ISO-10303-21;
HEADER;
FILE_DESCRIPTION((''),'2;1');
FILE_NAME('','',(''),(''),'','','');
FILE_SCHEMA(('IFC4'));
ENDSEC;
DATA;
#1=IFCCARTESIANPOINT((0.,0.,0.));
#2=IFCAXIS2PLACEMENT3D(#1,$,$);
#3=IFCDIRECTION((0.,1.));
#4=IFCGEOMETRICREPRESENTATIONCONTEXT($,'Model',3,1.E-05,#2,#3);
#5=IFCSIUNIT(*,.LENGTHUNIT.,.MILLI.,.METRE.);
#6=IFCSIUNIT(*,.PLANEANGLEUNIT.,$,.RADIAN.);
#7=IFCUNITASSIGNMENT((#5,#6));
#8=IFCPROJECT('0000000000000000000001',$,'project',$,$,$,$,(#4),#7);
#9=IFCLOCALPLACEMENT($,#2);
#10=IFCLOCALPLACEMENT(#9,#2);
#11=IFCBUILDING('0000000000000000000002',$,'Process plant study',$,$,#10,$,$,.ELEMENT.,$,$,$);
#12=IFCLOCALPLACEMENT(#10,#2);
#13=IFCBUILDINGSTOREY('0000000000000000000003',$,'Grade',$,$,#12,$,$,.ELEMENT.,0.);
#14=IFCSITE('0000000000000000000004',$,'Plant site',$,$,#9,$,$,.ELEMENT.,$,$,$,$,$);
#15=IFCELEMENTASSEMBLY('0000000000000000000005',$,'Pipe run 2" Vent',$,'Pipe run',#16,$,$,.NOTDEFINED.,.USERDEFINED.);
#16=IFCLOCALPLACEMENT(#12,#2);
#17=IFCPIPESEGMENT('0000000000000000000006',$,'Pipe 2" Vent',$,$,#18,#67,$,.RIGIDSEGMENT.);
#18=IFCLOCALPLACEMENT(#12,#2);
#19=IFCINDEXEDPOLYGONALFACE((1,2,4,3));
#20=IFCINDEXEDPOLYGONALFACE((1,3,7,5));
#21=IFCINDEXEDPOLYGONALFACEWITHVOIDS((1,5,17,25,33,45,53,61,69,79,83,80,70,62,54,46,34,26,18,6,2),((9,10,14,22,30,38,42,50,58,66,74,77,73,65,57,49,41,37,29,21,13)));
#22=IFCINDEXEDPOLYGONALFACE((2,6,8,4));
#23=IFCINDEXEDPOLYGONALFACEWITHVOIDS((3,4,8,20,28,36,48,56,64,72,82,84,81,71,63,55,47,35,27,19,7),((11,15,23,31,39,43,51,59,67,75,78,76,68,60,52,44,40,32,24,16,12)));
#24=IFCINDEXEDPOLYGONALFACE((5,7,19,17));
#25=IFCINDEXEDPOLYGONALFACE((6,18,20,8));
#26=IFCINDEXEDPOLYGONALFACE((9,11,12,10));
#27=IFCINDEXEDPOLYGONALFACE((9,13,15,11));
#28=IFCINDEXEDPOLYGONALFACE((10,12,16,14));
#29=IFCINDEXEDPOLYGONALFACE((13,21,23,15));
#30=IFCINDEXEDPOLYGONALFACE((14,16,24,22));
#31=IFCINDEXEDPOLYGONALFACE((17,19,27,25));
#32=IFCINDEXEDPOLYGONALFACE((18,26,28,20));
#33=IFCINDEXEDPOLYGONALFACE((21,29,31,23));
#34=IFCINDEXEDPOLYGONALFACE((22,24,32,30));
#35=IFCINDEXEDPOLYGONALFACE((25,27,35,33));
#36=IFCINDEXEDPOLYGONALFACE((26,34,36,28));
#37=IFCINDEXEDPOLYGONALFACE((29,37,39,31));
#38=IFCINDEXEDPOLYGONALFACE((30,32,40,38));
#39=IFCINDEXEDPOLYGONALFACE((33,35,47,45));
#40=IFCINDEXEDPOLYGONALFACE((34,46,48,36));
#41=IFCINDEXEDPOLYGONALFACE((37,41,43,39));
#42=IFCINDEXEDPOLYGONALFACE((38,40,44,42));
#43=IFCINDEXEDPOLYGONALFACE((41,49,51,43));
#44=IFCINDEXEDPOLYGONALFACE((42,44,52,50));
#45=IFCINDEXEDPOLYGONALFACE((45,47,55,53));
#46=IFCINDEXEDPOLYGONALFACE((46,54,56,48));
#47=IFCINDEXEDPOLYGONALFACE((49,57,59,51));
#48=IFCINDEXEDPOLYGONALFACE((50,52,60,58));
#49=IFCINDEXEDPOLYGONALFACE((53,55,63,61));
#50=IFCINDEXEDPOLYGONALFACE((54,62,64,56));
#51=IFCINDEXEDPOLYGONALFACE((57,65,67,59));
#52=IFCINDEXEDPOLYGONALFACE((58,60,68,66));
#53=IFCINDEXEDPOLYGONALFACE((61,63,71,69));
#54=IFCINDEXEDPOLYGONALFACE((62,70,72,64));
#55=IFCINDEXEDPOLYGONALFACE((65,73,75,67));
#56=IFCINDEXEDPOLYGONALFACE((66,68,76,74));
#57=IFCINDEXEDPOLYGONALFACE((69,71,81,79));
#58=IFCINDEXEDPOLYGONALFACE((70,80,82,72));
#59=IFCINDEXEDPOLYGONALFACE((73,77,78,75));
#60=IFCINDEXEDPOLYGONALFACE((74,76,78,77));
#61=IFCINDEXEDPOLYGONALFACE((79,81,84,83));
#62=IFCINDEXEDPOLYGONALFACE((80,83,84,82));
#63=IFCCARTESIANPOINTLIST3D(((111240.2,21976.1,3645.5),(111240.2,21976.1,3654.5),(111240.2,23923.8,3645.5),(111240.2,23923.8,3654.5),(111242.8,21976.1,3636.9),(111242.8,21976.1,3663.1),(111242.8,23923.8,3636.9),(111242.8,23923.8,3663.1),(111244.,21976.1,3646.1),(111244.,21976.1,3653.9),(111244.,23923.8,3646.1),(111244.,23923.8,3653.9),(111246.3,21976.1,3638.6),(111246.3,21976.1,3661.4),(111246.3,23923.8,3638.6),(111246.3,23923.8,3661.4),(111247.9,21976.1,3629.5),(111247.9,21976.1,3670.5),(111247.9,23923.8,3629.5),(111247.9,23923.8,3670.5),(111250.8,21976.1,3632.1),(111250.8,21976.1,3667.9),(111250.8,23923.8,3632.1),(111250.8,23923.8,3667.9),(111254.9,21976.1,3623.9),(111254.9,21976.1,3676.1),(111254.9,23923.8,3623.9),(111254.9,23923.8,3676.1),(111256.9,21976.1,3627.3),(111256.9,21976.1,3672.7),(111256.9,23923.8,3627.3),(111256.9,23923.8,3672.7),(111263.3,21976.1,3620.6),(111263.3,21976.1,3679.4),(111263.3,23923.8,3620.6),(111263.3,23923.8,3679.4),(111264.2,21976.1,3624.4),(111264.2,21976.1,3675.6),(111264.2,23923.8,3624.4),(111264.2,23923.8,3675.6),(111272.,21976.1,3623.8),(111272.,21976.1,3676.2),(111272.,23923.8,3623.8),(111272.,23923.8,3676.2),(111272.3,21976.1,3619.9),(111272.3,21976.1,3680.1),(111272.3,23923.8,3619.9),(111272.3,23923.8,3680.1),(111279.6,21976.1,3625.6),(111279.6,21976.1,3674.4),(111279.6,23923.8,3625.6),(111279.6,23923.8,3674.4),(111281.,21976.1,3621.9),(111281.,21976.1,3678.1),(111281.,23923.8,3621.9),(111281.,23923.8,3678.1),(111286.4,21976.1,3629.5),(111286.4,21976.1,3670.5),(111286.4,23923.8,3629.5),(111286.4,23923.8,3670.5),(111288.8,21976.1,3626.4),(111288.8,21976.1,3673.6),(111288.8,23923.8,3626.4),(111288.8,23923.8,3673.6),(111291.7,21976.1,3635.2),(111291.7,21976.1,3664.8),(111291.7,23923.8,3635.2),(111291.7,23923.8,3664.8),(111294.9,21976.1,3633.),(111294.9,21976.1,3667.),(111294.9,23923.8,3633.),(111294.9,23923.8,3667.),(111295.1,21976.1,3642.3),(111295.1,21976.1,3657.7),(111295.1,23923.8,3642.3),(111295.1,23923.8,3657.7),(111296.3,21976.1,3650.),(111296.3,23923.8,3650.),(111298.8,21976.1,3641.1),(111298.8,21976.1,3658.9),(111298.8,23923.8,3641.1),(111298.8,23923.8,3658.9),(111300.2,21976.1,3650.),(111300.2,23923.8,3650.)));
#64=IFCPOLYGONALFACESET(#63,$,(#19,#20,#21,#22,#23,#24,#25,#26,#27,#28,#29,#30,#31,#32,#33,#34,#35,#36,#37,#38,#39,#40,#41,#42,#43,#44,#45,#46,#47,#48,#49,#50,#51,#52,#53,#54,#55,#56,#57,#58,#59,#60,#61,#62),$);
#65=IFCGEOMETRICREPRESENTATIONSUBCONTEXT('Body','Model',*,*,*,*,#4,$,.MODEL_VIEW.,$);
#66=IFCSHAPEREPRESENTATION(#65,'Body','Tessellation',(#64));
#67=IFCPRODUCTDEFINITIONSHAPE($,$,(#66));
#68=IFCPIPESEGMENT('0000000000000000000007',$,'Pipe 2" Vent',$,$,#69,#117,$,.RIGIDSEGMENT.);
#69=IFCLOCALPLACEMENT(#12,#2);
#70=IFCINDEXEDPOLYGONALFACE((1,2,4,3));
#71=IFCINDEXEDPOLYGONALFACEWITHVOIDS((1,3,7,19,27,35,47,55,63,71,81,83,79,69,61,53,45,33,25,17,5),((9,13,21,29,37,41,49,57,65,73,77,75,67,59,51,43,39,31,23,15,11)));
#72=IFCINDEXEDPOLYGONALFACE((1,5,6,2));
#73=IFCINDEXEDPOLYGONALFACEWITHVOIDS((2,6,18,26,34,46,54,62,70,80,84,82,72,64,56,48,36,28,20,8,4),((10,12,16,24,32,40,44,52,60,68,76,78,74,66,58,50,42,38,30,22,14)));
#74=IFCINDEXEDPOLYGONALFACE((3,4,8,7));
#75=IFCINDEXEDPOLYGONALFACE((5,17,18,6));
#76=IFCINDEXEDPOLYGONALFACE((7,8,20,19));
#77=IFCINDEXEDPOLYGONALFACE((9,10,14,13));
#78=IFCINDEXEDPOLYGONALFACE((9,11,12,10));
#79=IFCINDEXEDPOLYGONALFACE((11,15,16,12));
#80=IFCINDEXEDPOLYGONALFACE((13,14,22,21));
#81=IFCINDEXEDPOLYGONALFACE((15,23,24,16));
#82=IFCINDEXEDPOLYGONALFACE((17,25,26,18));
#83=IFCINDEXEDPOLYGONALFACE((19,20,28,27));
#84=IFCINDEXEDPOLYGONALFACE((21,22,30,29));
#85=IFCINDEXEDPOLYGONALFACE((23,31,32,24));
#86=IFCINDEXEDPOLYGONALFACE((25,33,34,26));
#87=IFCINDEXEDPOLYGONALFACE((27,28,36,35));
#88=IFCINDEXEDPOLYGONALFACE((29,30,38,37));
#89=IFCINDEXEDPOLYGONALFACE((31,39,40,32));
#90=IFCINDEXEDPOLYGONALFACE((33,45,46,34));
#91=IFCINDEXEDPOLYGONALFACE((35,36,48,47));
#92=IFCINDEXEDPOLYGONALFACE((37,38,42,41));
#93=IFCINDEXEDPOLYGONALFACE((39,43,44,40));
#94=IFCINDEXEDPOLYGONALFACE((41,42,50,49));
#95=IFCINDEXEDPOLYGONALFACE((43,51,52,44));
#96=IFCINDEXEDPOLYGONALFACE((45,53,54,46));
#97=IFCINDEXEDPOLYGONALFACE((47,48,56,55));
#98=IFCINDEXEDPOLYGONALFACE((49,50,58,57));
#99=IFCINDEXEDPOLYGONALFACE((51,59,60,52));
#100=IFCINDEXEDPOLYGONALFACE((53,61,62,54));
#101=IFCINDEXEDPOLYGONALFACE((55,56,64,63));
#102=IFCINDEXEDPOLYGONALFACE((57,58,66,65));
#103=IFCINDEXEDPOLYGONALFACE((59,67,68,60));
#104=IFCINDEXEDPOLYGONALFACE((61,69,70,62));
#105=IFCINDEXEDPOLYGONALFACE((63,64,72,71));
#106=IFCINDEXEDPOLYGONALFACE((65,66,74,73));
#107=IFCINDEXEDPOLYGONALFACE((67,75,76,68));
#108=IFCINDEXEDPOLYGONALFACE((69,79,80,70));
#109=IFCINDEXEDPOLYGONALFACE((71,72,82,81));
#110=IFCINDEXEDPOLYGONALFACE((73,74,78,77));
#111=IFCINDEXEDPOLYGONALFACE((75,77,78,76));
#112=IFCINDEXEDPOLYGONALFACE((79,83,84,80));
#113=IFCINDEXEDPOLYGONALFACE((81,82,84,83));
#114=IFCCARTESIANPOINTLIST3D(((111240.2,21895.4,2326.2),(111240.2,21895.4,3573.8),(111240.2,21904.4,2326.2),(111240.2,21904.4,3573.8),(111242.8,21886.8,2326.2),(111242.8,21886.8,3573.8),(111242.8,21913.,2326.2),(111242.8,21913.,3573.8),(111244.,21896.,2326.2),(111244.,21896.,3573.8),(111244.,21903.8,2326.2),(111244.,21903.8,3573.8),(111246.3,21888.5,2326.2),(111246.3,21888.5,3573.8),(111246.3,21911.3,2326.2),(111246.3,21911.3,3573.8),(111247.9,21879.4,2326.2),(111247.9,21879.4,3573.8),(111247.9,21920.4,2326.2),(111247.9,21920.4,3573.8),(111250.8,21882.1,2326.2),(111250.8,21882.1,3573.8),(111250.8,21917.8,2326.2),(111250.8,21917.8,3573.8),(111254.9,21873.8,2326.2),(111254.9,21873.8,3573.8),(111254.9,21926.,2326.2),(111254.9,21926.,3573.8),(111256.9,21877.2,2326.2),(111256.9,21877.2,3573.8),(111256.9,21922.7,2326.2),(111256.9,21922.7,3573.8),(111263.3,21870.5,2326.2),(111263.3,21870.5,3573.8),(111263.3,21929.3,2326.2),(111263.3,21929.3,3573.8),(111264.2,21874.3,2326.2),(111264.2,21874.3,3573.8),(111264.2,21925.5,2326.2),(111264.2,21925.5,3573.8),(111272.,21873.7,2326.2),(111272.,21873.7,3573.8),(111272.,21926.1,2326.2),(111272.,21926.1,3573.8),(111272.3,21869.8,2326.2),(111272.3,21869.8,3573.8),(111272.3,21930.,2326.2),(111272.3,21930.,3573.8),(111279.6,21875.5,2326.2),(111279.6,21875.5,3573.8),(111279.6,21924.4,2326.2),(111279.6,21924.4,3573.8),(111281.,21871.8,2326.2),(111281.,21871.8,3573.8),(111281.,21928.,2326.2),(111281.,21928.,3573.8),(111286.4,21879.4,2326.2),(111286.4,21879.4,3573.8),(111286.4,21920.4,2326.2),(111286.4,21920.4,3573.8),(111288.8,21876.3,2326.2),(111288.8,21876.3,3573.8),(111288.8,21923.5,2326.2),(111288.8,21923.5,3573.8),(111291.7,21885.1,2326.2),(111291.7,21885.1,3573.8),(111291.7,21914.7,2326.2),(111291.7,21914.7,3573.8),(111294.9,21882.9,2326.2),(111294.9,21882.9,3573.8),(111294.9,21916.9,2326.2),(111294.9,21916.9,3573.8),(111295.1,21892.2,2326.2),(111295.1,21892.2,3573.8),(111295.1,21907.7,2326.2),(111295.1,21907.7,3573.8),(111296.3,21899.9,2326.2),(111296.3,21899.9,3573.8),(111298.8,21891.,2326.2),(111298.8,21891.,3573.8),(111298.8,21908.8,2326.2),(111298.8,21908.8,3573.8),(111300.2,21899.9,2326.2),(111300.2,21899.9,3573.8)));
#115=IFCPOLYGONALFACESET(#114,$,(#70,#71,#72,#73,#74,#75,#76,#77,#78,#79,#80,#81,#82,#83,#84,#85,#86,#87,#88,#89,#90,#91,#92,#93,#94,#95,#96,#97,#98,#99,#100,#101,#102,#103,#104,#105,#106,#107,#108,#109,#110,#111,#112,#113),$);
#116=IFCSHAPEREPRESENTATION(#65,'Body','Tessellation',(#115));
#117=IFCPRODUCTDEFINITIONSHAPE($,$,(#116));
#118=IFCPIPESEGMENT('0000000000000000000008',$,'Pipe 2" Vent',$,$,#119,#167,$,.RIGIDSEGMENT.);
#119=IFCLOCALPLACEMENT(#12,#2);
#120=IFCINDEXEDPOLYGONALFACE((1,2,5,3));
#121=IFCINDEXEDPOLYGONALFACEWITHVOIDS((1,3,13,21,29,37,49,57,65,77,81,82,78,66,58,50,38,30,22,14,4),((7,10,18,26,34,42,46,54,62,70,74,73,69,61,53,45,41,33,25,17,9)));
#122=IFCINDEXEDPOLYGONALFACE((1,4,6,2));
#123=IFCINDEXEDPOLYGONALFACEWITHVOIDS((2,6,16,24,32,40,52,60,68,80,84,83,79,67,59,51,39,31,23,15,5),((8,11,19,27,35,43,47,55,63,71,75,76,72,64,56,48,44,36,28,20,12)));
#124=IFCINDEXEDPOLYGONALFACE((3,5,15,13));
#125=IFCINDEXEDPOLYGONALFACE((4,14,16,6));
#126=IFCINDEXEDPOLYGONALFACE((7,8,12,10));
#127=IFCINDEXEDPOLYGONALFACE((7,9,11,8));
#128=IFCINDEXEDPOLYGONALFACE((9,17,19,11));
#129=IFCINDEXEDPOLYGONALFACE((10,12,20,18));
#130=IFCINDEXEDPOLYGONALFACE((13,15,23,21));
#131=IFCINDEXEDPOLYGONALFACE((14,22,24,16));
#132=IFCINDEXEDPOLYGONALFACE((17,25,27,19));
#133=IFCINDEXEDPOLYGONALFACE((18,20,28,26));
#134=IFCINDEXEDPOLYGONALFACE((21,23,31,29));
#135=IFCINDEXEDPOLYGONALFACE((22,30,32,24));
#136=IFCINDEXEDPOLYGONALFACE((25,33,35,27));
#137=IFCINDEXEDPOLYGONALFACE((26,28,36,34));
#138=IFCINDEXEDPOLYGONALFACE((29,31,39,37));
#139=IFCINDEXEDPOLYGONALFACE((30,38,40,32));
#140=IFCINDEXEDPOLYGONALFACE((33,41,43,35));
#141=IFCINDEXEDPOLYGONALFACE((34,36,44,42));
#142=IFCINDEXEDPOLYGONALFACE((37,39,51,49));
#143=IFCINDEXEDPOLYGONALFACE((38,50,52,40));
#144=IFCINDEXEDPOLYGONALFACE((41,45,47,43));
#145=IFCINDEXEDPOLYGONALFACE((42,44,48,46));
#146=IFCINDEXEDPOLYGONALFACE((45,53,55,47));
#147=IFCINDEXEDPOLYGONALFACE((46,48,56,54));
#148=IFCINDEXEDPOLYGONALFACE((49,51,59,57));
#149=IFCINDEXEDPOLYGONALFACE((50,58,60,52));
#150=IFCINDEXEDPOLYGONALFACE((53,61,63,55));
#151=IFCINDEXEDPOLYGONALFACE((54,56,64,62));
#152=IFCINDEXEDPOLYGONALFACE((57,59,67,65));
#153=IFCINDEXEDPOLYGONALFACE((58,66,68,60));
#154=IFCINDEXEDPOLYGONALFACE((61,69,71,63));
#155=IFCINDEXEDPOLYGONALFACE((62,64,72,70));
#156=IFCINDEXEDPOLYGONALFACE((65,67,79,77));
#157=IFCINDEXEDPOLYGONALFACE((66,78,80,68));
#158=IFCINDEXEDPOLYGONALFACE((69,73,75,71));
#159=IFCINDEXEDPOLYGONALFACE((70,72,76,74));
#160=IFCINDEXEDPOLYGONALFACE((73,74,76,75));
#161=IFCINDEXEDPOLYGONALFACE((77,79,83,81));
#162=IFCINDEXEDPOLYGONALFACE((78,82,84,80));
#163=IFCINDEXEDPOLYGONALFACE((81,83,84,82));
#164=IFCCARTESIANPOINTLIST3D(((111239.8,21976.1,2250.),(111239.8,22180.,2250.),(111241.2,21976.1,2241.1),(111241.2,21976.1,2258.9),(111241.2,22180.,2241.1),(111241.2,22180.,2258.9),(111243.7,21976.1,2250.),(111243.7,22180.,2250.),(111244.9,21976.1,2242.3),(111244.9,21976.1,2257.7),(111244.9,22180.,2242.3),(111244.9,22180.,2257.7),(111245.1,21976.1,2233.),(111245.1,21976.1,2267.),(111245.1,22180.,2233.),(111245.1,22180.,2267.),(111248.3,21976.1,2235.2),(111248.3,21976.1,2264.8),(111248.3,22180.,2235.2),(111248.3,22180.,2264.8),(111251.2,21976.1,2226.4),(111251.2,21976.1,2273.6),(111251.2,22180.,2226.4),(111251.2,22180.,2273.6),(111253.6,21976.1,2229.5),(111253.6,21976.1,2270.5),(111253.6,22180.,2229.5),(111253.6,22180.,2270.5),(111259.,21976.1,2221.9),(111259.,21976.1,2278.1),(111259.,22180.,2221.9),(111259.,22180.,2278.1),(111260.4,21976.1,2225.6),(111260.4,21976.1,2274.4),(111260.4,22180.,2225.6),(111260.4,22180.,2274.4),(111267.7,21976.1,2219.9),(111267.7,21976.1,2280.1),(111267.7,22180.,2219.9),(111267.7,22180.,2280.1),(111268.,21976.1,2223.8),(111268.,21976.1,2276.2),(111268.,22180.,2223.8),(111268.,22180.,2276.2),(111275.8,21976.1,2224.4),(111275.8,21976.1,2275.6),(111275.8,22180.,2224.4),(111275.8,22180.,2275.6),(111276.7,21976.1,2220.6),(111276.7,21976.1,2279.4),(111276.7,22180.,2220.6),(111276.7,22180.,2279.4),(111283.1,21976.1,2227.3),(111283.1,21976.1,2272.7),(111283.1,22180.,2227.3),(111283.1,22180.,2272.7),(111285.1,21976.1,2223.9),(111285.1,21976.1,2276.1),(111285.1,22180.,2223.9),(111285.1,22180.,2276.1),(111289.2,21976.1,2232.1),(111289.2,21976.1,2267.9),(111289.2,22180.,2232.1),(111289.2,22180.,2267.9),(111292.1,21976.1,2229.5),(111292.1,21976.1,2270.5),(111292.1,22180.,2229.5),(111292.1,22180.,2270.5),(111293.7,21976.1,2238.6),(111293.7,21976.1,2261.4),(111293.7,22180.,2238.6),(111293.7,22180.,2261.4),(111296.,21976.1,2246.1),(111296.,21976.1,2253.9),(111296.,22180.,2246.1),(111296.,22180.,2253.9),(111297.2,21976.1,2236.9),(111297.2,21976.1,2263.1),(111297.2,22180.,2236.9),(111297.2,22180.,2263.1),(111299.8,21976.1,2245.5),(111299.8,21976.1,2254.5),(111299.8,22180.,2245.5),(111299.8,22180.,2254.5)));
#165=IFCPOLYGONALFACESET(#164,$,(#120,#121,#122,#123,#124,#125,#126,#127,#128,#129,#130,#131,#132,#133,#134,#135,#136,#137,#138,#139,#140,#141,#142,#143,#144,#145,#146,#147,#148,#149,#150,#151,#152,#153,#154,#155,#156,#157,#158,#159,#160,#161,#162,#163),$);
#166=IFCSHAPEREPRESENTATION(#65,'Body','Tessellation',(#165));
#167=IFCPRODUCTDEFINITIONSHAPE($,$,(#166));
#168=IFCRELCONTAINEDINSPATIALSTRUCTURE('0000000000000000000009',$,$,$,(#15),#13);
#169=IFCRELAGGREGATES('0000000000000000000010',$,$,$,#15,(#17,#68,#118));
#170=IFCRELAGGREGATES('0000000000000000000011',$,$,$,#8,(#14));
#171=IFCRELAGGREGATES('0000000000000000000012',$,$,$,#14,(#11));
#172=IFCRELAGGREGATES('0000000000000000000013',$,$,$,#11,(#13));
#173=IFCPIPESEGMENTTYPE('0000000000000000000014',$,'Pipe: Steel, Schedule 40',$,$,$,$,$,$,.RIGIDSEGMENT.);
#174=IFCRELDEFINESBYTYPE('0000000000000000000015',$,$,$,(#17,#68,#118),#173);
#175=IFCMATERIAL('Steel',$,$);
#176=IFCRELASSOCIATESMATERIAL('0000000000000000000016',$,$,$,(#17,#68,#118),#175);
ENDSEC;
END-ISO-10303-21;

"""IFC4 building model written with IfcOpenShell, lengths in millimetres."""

from ifc_helpers import new_model, si_unit, direction, frame, origin, origin_with_axes, origin_2d, place, context, subcontext, project, spatial, hollow_circle, extrude, material, type_object, element, aggregate, save


model = new_model("IFC4")

# Units and contexts
model_context = context("Model", 3, precision=1e-05, world=origin(), true_north=direction((0.0, 1.0)))
body_context = subcontext(model_context, "Body", "Model", "MODEL_VIEW")
ifc_project = project(units=[si_unit("LENGTHUNIT", "METRE", prefix="MILLI"), si_unit("PLANEANGLEUNIT", "RADIAN")], contexts=[model_context])

# Site, building, storey
site_placement = place(None, origin())
site = spatial("IfcSite", under=ifc_project, at=site_placement, Name="Plant site", CompositionType="ELEMENT")
building_placement = place(site_placement, origin())
building = spatial("IfcBuilding", under=site, at=building_placement, Name="Process plant study", CompositionType="ELEMENT")
storey_placement = place(building_placement, origin())
storey = spatial("IfcBuildingStorey", under=building, at=storey_placement, Name="Grade", CompositionType="ELEMENT", Elevation=0.0)

# Shared definitions
ifc_material = material(Name="Steel")
pipe_segment_type = type_object("IfcPipeSegmentType", Name="Pipe: Steel, Schedule 40", PredefinedType="RIGIDSEGMENT")

# Element assembly, pipe segments
assembly_1_placement = place(storey_placement, origin_with_axes())
assembly_1 = element("IfcElementAssembly", 1, at=assembly_1_placement, inside=storey, Name="Pipe run 2\" Vent", ObjectType="Pipe run", AssemblyPlace="NOTDEFINED", PredefinedType="USERDEFINED")
pipe_segment_1_placement = place(storey_placement, origin_with_axes())
pipe_segment_1 = element("IfcPipeSegment", 2, at=pipe_segment_1_placement, type_object=pipe_segment_type, material=ifc_material, Name="Pipe 2\" Vent", PredefinedType="RIGIDSEGMENT", context=body_context, shape_type="SweptSolid", body=[
    extrude(hollow_circle(Radius=30.2, WallThickness=3.9, at=origin_2d()), frame((111270.0, 23923.8, 3650.0), z_axis=(0.0, -1.0, 0.0), x_axis=(1.0, 0.0, 0.0)), (0.0, 0.0, 1.0), 1947.7),
])
pipe_segment_2_placement = place(storey_placement, origin_with_axes())
pipe_segment_2 = element("IfcPipeSegment", 3, at=pipe_segment_2_placement, type_object=pipe_segment_type, material=ifc_material, Name="Pipe 2\" Vent", PredefinedType="RIGIDSEGMENT", context=body_context, shape_type="SweptSolid", body=[
    extrude(hollow_circle(Radius=30.2, WallThickness=3.9, at=origin_2d()), frame((111270.0, 21899.9, 3573.8), z_axis=(0.0, 0.0, -1.0), x_axis=(1.0, 0.0, 0.0)), (0.0, 0.0, 1.0), 1247.6),
])
pipe_segment_3_placement = place(storey_placement, origin_with_axes())
pipe_segment_3 = element("IfcPipeSegment", 4, at=pipe_segment_3_placement, type_object=pipe_segment_type, material=ifc_material, Name="Pipe 2\" Vent", PredefinedType="RIGIDSEGMENT", context=body_context, shape_type="SweptSolid", body=[
    extrude(hollow_circle(Radius=30.2, WallThickness=3.9, at=origin_2d()), frame((111270.0, 21976.1, 2250.0), z_axis=(0.0, 1.0, 0.0), x_axis=(-1.0, 0.0, 0.0)), (0.0, 0.0, 1.0), 203.9),
])

aggregate(assembly_1, [pipe_segment_1, pipe_segment_2, pipe_segment_3])

save(model, "model.ifc")
